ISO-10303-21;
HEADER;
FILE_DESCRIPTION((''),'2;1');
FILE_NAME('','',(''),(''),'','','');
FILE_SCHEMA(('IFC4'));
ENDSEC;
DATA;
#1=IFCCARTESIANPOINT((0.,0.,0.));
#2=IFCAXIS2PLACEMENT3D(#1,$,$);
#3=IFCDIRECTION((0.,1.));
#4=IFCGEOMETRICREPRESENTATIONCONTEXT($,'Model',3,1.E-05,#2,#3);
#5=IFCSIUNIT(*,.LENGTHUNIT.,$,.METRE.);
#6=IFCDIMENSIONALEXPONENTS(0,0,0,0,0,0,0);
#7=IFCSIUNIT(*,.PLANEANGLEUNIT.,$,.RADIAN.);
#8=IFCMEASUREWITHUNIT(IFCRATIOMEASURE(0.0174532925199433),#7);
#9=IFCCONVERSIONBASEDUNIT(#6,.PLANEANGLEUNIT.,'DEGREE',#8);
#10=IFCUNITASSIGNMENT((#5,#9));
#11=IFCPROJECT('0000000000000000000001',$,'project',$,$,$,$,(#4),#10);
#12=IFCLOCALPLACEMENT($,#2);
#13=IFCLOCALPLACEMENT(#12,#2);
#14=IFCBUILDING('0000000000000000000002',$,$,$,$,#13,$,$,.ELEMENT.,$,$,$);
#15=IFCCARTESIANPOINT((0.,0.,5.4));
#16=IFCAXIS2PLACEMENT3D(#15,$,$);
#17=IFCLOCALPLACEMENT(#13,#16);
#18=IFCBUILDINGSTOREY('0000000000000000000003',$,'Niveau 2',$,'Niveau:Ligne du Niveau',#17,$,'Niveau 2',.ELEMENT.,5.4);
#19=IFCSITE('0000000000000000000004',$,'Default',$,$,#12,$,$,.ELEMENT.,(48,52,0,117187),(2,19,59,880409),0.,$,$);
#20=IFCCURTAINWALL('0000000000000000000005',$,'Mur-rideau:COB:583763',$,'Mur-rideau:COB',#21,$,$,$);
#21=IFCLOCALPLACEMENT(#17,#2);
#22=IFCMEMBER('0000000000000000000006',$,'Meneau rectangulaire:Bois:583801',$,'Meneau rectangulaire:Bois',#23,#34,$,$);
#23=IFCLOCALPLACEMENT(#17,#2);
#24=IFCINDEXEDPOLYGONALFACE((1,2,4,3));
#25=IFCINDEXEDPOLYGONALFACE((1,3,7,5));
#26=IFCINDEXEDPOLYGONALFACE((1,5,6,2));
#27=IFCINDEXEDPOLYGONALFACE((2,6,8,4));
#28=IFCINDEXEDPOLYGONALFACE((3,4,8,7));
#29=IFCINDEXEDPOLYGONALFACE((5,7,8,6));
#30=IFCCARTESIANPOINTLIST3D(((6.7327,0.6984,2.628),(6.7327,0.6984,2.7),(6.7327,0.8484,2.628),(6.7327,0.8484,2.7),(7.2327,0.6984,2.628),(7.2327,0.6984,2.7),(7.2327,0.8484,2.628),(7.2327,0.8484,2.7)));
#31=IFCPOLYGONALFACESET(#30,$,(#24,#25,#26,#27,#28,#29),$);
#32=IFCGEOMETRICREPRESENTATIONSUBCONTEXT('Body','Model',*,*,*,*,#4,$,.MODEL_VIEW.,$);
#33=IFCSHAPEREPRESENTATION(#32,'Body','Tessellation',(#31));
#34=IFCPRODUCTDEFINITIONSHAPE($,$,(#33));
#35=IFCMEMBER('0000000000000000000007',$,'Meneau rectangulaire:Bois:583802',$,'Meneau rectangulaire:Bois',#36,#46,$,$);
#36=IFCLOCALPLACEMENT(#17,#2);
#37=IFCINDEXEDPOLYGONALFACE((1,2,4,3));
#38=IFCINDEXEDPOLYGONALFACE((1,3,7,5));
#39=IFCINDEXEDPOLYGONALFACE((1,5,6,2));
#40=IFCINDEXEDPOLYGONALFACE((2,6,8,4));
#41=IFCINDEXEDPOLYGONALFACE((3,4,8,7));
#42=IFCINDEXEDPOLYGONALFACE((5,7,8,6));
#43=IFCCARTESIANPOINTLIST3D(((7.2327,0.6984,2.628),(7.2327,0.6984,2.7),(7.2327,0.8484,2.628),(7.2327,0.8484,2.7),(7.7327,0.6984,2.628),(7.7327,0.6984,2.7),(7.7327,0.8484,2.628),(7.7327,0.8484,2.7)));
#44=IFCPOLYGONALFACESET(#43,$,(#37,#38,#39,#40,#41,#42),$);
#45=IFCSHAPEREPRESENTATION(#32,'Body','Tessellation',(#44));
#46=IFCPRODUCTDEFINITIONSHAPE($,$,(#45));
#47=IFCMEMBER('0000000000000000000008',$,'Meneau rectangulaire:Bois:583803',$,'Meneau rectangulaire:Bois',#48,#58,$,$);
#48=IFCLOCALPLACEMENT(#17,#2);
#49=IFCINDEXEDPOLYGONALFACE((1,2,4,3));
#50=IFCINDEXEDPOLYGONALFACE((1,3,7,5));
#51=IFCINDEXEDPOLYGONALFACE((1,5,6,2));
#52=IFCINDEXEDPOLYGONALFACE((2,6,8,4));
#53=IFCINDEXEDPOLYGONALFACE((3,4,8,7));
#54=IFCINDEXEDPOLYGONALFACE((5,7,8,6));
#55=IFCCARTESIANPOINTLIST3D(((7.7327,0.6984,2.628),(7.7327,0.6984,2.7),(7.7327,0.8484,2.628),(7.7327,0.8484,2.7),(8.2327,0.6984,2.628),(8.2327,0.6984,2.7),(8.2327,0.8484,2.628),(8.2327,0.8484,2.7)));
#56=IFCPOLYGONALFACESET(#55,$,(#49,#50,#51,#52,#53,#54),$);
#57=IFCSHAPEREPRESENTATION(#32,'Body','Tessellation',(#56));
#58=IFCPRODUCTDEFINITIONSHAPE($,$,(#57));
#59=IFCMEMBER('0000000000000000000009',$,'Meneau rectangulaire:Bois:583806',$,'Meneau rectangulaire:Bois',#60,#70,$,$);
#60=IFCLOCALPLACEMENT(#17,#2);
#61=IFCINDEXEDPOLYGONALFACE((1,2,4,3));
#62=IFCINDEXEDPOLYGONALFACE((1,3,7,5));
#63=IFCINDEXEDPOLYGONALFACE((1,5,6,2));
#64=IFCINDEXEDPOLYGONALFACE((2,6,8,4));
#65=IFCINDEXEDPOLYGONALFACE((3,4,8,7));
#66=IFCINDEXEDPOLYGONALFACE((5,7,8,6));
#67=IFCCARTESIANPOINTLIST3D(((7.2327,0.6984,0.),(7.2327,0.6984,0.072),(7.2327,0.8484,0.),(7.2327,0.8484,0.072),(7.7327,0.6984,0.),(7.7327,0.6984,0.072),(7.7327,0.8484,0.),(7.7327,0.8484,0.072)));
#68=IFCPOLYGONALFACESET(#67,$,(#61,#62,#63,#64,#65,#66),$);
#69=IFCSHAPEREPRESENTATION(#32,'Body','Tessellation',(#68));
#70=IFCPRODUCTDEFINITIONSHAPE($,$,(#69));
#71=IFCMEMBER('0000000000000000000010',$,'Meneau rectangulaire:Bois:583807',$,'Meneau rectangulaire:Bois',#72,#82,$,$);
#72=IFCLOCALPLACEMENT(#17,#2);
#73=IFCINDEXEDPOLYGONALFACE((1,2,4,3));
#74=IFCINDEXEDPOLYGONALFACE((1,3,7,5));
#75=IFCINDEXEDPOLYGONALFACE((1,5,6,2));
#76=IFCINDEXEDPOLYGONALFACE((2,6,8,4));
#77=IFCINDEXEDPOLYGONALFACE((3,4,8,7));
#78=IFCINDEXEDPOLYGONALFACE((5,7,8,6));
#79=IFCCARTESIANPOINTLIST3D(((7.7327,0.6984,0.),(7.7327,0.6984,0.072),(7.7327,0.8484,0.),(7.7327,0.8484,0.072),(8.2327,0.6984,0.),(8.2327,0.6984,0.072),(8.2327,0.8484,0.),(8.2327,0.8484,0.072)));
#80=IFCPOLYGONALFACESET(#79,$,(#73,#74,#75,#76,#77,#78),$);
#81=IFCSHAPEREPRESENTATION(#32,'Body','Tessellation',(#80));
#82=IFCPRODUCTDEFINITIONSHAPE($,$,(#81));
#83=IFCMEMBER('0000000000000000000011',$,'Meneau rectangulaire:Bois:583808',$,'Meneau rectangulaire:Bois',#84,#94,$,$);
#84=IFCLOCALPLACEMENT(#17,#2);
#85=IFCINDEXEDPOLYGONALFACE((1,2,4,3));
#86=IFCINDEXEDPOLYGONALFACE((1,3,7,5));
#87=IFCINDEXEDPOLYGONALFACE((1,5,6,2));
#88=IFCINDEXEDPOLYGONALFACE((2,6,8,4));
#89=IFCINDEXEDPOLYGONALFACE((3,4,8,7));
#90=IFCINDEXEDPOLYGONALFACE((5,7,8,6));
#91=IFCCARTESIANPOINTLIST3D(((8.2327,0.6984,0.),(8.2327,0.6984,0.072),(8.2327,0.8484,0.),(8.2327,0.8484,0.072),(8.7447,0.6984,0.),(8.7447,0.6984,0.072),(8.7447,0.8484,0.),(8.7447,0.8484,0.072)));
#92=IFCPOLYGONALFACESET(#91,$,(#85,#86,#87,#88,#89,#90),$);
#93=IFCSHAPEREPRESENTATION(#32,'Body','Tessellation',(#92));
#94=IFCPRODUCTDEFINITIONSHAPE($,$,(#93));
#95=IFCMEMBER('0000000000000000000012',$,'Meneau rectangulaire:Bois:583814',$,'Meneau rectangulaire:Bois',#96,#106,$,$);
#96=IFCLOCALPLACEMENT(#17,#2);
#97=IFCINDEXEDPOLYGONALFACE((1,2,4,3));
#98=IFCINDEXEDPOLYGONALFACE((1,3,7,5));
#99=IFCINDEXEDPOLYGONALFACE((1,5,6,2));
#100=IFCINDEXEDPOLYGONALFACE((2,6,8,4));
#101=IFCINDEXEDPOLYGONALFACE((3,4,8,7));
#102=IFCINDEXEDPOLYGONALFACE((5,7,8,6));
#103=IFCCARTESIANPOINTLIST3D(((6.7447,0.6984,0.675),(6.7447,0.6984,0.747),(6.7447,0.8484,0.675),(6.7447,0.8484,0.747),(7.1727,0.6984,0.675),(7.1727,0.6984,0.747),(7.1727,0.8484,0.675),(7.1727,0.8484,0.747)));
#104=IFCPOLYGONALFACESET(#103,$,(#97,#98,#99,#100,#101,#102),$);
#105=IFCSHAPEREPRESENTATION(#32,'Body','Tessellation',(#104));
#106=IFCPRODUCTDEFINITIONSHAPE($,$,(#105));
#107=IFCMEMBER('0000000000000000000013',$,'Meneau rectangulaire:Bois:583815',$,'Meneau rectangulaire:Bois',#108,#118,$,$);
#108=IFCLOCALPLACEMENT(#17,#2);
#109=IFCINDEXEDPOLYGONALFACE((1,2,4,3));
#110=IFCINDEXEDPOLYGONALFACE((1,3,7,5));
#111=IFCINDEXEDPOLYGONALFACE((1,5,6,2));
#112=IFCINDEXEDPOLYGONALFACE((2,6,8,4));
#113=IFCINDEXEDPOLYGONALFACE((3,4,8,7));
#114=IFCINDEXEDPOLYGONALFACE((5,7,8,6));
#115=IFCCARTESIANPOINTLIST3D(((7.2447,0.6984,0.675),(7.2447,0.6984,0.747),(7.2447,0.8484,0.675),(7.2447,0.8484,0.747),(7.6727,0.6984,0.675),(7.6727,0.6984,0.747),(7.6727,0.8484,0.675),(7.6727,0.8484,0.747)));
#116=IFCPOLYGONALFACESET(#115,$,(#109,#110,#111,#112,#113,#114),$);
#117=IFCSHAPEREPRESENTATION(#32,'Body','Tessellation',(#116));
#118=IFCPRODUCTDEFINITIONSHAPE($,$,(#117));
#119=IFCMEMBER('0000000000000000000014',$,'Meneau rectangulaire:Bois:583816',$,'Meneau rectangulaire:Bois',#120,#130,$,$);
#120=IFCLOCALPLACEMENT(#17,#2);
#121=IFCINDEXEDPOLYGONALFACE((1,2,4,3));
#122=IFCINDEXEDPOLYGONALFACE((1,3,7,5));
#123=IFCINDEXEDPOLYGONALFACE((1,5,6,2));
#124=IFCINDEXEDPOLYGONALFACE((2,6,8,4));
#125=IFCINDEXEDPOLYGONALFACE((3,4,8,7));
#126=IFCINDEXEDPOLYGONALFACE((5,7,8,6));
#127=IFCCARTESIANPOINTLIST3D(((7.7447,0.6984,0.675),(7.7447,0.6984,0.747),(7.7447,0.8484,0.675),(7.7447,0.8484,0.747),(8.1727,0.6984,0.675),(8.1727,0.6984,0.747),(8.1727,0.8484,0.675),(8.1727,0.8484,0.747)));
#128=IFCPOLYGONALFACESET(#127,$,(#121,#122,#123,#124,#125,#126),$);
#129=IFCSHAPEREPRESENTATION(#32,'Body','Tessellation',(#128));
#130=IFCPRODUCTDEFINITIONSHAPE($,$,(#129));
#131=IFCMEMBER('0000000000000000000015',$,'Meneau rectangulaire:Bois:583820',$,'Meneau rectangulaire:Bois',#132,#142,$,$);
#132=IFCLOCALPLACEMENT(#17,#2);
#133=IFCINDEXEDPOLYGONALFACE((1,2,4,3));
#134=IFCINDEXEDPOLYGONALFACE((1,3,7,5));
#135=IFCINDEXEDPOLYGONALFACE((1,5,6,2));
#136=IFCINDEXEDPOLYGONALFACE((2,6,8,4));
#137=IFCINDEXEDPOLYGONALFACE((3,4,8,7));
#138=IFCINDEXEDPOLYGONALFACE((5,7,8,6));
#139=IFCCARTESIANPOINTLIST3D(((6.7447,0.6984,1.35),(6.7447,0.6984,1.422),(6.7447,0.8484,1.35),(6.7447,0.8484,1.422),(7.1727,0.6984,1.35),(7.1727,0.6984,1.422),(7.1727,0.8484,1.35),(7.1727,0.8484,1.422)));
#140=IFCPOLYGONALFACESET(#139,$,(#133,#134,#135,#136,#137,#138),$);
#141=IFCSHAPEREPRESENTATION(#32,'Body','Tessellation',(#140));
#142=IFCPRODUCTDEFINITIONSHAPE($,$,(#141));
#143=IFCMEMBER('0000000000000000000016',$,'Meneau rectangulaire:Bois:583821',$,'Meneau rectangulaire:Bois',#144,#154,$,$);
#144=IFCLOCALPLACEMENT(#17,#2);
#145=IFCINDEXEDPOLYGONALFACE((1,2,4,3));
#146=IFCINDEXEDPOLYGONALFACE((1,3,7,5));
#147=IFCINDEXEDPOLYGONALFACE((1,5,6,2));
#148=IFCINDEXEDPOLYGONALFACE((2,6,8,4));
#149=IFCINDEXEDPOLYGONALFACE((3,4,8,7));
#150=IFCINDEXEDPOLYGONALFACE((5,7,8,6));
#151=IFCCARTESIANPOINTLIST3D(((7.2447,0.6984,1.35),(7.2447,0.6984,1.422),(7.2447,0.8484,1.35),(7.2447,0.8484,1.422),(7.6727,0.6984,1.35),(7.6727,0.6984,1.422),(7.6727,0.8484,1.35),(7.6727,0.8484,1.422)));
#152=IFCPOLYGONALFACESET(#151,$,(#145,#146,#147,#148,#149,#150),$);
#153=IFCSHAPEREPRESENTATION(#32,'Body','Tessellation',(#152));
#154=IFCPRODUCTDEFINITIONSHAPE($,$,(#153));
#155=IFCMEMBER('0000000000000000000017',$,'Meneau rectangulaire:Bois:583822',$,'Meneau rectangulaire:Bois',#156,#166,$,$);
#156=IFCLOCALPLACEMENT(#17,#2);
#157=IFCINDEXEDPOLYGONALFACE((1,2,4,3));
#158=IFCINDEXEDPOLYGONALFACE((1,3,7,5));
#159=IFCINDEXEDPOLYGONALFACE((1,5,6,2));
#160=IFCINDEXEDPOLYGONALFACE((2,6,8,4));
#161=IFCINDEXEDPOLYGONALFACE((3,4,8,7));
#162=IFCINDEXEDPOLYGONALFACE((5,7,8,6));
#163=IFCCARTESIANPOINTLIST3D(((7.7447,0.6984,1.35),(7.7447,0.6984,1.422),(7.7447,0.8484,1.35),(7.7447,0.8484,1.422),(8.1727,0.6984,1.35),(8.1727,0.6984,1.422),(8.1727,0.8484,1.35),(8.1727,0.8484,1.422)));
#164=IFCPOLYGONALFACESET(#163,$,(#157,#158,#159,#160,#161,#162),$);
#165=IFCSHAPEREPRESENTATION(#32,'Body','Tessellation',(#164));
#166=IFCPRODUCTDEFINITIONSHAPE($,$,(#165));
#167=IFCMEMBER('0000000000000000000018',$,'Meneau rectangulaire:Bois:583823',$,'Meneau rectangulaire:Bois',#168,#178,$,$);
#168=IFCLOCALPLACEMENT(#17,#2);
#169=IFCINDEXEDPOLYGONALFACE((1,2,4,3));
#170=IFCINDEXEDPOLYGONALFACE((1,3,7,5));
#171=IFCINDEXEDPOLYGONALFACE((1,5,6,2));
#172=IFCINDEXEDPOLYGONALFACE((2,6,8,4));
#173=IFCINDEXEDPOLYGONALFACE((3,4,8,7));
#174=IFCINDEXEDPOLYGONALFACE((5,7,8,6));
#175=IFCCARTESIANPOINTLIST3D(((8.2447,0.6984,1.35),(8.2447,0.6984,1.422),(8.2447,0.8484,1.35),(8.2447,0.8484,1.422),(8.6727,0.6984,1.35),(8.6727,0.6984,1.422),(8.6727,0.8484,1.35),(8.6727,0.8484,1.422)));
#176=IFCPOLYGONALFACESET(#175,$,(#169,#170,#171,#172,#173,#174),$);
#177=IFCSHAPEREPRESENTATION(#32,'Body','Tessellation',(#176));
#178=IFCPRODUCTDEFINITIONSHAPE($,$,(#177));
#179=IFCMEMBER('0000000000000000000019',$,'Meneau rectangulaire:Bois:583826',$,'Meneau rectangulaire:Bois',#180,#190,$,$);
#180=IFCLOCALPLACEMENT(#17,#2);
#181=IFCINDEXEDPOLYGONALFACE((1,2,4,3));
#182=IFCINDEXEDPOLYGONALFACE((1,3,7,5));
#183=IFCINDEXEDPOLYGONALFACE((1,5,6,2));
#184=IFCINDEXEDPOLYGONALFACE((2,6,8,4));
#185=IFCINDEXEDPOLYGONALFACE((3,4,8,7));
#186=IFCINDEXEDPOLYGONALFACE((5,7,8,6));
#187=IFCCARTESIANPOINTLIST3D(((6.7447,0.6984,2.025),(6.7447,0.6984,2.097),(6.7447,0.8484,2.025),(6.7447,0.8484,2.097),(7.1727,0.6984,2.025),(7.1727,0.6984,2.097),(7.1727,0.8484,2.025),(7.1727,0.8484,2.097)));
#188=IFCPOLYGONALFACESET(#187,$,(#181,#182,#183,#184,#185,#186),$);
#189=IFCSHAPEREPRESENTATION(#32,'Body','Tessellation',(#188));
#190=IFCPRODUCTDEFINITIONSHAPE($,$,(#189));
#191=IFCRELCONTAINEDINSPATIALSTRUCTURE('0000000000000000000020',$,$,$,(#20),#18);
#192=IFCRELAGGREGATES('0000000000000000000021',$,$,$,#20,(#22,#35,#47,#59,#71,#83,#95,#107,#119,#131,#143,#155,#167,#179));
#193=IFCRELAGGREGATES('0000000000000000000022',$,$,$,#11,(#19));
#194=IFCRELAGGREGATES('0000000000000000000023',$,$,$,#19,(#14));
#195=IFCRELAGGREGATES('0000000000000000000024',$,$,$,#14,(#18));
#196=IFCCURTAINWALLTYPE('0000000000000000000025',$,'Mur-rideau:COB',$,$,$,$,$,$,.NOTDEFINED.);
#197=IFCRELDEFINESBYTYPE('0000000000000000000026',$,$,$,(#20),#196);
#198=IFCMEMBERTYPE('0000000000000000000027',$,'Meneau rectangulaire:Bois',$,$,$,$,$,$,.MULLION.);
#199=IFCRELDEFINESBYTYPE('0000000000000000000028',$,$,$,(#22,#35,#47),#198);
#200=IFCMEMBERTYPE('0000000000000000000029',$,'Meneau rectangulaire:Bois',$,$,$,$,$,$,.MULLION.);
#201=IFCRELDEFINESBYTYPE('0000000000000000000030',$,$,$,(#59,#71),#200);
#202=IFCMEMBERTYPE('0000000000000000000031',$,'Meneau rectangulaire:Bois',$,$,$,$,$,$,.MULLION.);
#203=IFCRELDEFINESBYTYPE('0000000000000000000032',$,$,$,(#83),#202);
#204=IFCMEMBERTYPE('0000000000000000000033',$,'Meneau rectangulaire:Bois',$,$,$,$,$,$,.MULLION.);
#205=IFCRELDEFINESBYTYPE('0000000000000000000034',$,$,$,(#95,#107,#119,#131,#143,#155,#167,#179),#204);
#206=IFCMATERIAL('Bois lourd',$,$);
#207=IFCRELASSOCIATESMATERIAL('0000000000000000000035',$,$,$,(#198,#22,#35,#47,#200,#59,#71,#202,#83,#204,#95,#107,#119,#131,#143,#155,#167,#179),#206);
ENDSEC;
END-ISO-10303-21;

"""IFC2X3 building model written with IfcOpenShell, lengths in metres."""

from ifc_helpers import new_model, entity, si_unit, converted_unit, direction, frame, origin, origin_2d_with_axis, place, context, subcontext, project, spatial, rectangle, extrude, source, transform, mapped, material, type_object, type_shapes, element, aggregate, save


model = new_model("IFC2X3")

# Units and contexts
model_context = context("Model", 3, precision=1e-05, world=origin(), true_north=direction((0.0, 1.0)))
body_context = subcontext(model_context, "Body", "Model", "MODEL_VIEW")
ifc_project = project(units=[si_unit("LENGTHUNIT", "METRE"), converted_unit("PLANEANGLEUNIT", "DEGREE", entity("IfcRatioMeasure", 0.0174532925199433), si_unit("PLANEANGLEUNIT", "RADIAN"), dimensions=[0, 0, 0, 0, 0, 0, 0])], contexts=[model_context])

# Site, building, storey
site_placement = place(None, origin())
site = spatial("IfcSite", under=ifc_project, at=site_placement, Name="Default", CompositionType="ELEMENT", RefLatitude=(48, 52, 0, 117187), RefLongitude=(2, 19, 59, 880409), RefElevation=0.0)
building_placement = place(site_placement, origin())
building = spatial("IfcBuilding", under=site, at=building_placement, CompositionType="ELEMENT")
storey_placement = place(building_placement, frame((0.0, 0.0, 5.4)))
storey = spatial("IfcBuildingStorey", under=building, at=storey_placement, Name="Niveau 2", ObjectType="Niveau:Ligne du Niveau", LongName="Niveau 2", CompositionType="ELEMENT", Elevation=5.4)

# Curtain wall, members
curtain_wall_type_1 = type_object("IfcCurtainWallType", Name="Mur-rideau:COB", PredefinedType="NOTDEFINED")
curtain_wall_1_placement = place(storey_placement, frame((0.0, 0.0, -5.4)))
curtain_wall_1 = element("IfcCurtainWall", 1, at=curtain_wall_1_placement, inside=storey, type_object=curtain_wall_type_1, Name="Mur-rideau:COB:583763", ObjectType="Mur-rideau:COB")
ifc_material_1 = material(Name="Bois lourd")
member_type_1 = type_object("IfcMemberType", Name="Meneau rectangulaire:Bois", PredefinedType="MULLION", material=ifc_material_1)
shared_shape_1 = source(origin(), body_context, "Body", "SweptSolid", [
    extrude(rectangle(XDim=0.15, YDim=0.072, at=origin_2d_with_axis()), frame((-0.036, 0.0, -0.5), z_axis=(0.0, 0.0, 1.0), x_axis=(0.0, -1.0, 0.0)), (0.0, 0.0, 1.0), 0.5),
])
type_shapes(member_type_1, [shared_shape_1])
member_1_placement = place(storey_placement, frame((7.2327, 0.7734, 2.7), z_axis=(1.0, 0.0, 0.0), x_axis=(0.0, 0.0, 1.0)))
member_1 = element("IfcMember", 2, at=member_1_placement, type_object=member_type_1, material=ifc_material_1, Name="Meneau rectangulaire:Bois:583801", ObjectType="Meneau rectangulaire:Bois", context=body_context, shape_type="MappedRepresentation", body=[
    mapped(shared_shape_1, transform((0.0, 0.0, 0.0), scale=1.0)),
])
member_2_placement = place(storey_placement, frame((7.7327, 0.7734, 2.7), z_axis=(1.0, 0.0, 0.0), x_axis=(0.0, 0.0, 1.0)))
member_2 = element("IfcMember", 3, at=member_2_placement, type_object=member_type_1, material=ifc_material_1, Name="Meneau rectangulaire:Bois:583802", ObjectType="Meneau rectangulaire:Bois", context=body_context, shape_type="MappedRepresentation", body=[
    mapped(shared_shape_1, transform((0.0, 0.0, 0.0), scale=1.0)),
])
member_3_placement = place(storey_placement, frame((8.2327, 0.7734, 2.7), z_axis=(1.0, 0.0, 0.0), x_axis=(0.0, 0.0, 1.0)))
member_3 = element("IfcMember", 4, at=member_3_placement, type_object=member_type_1, material=ifc_material_1, Name="Meneau rectangulaire:Bois:583803", ObjectType="Meneau rectangulaire:Bois", context=body_context, shape_type="MappedRepresentation", body=[
    mapped(shared_shape_1, transform((0.0, 0.0, 0.0), scale=1.0)),
])
member_type_2 = type_object("IfcMemberType", Name="Meneau rectangulaire:Bois", PredefinedType="MULLION", material=ifc_material_1)
shared_shape_2 = source(origin(), body_context, "Body", "SweptSolid", [
    extrude(rectangle(XDim=0.15, YDim=0.072, at=origin_2d_with_axis()), frame((-0.036, 0.0, -0.5), z_axis=(0.0, 0.0, 1.0), x_axis=(0.0, -1.0, 0.0)), (0.0, 0.0, 1.0), 0.5),
])
type_shapes(member_type_2, [shared_shape_2])
member_4_placement = place(storey_placement, frame((7.2327, 0.7734, 0.0), z_axis=(-1.0, 0.0, 0.0), x_axis=(0.0, 0.0, -1.0)))
member_4 = element("IfcMember", 5, at=member_4_placement, type_object=member_type_2, material=ifc_material_1, Name="Meneau rectangulaire:Bois:583806", ObjectType="Meneau rectangulaire:Bois", context=body_context, shape_type="MappedRepresentation", body=[
    mapped(shared_shape_2, transform((0.0, 0.0, 0.0), scale=1.0)),
])
member_5_placement = place(storey_placement, frame((7.7327, 0.7734, 0.0), z_axis=(-1.0, 0.0, 0.0), x_axis=(0.0, 0.0, -1.0)))
member_5 = element("IfcMember", 6, at=member_5_placement, type_object=member_type_2, material=ifc_material_1, Name="Meneau rectangulaire:Bois:583807", ObjectType="Meneau rectangulaire:Bois", context=body_context, shape_type="MappedRepresentation", body=[
    mapped(shared_shape_2, transform((0.0, 0.0, 0.0), scale=1.0)),
])
member_type_3 = type_object("IfcMemberType", Name="Meneau rectangulaire:Bois", PredefinedType="MULLION", material=ifc_material_1)
shared_shape_3 = source(origin(), body_context, "Body", "SweptSolid", [
    extrude(rectangle(XDim=0.15, YDim=0.072, at=origin_2d_with_axis()), frame((-0.036, 0.0, -0.512), z_axis=(0.0, 0.0, 1.0), x_axis=(0.0, -1.0, 0.0)), (0.0, 0.0, 1.0), 0.512),
])
type_shapes(member_type_3, [shared_shape_3])
member_6_placement = place(storey_placement, frame((8.2327, 0.7734, 0.0), z_axis=(-1.0, 0.0, 0.0), x_axis=(0.0, 0.0, -1.0)))
member_6 = element("IfcMember", 7, at=member_6_placement, type_object=member_type_3, material=ifc_material_1, Name="Meneau rectangulaire:Bois:583808", ObjectType="Meneau rectangulaire:Bois", context=body_context, shape_type="MappedRepresentation", body=[
    mapped(shared_shape_3, transform((0.0, 0.0, 0.0), scale=1.0)),
])
member_type_4 = type_object("IfcMemberType", Name="Meneau rectangulaire:Bois", PredefinedType="MULLION", material=ifc_material_1)
shared_shape_4 = source(origin(), body_context, "Body", "SweptSolid", [
    extrude(rectangle(XDim=0.15, YDim=0.072, at=origin_2d_with_axis()), frame((-0.024, 0.0, -0.428), z_axis=(0.0, 0.0, 1.0), x_axis=(0.0, -1.0, 0.0)), (0.0, 0.0, 1.0), 0.428),
])
type_shapes(member_type_4, [shared_shape_4])
member_7_placement = place(storey_placement, frame((7.1727, 0.7734, 0.735), z_axis=(1.0, 0.0, 0.0), x_axis=(0.0, 0.0, 1.0)))
member_7 = element("IfcMember", 8, at=member_7_placement, type_object=member_type_4, material=ifc_material_1, Name="Meneau rectangulaire:Bois:583814", ObjectType="Meneau rectangulaire:Bois", context=body_context, shape_type="MappedRepresentation", body=[
    mapped(shared_shape_4, transform((0.0, 0.0, 0.0), scale=1.0)),
])
member_8_placement = place(storey_placement, frame((7.6727, 0.7734, 0.735), z_axis=(1.0, 0.0, 0.0), x_axis=(0.0, 0.0, 1.0)))
member_8 = element("IfcMember", 9, at=member_8_placement, type_object=member_type_4, material=ifc_material_1, Name="Meneau rectangulaire:Bois:583815", ObjectType="Meneau rectangulaire:Bois", context=body_context, shape_type="MappedRepresentation", body=[
    mapped(shared_shape_4, transform((0.0, 0.0, 0.0), scale=1.0)),
])
member_9_placement = place(storey_placement, frame((8.1727, 0.7734, 0.735), z_axis=(1.0, 0.0, 0.0), x_axis=(0.0, 0.0, 1.0)))
member_9 = element("IfcMember", 10, at=member_9_placement, type_object=member_type_4, material=ifc_material_1, Name="Meneau rectangulaire:Bois:583816", ObjectType="Meneau rectangulaire:Bois", context=body_context, shape_type="MappedRepresentation", body=[
    mapped(shared_shape_4, transform((0.0, 0.0, 0.0), scale=1.0)),
])
member_10_placement = place(storey_placement, frame((7.1727, 0.7734, 1.41), z_axis=(1.0, 0.0, 0.0), x_axis=(0.0, 0.0, 1.0)))
member_10 = element("IfcMember", 11, at=member_10_placement, type_object=member_type_4, material=ifc_material_1, Name="Meneau rectangulaire:Bois:583820", ObjectType="Meneau rectangulaire:Bois", context=body_context, shape_type="MappedRepresentation", body=[
    mapped(shared_shape_4, transform((0.0, 0.0, 0.0), scale=1.0)),
])
member_11_placement = place(storey_placement, frame((7.6727, 0.7734, 1.41), z_axis=(1.0, 0.0, 0.0), x_axis=(0.0, 0.0, 1.0)))
member_11 = element("IfcMember", 12, at=member_11_placement, type_object=member_type_4, material=ifc_material_1, Name="Meneau rectangulaire:Bois:583821", ObjectType="Meneau rectangulaire:Bois", context=body_context, shape_type="MappedRepresentation", body=[
    mapped(shared_shape_4, transform((0.0, 0.0, 0.0), scale=1.0)),
])
member_12_placement = place(storey_placement, frame((8.1727, 0.7734, 1.41), z_axis=(1.0, 0.0, 0.0), x_axis=(0.0, 0.0, 1.0)))
member_12 = element("IfcMember", 13, at=member_12_placement, type_object=member_type_4, material=ifc_material_1, Name="Meneau rectangulaire:Bois:583822", ObjectType="Meneau rectangulaire:Bois", context=body_context, shape_type="MappedRepresentation", body=[
    mapped(shared_shape_4, transform((0.0, 0.0, 0.0), scale=1.0)),
])
member_13_placement = place(storey_placement, frame((8.6727, 0.7734, 1.41), z_axis=(1.0, 0.0, 0.0), x_axis=(0.0, 0.0, 1.0)))
member_13 = element("IfcMember", 14, at=member_13_placement, type_object=member_type_4, material=ifc_material_1, Name="Meneau rectangulaire:Bois:583823", ObjectType="Meneau rectangulaire:Bois", context=body_context, shape_type="MappedRepresentation", body=[
    mapped(shared_shape_4, transform((0.0, 0.0, 0.0), scale=1.0)),
])
member_14_placement = place(storey_placement, frame((7.1727, 0.7734, 2.085), z_axis=(1.0, 0.0, 0.0), x_axis=(0.0, 0.0, 1.0)))
member_14 = element("IfcMember", 15, at=member_14_placement, type_object=member_type_4, material=ifc_material_1, Name="Meneau rectangulaire:Bois:583826", ObjectType="Meneau rectangulaire:Bois", context=body_context, shape_type="MappedRepresentation", body=[
    mapped(shared_shape_4, transform((0.0, 0.0, 0.0), scale=1.0)),
])
aggregate(curtain_wall_1, [member_1, member_2, member_3, member_4, member_5, member_6, member_7, member_8, member_9, member_10, member_11, member_12, member_13, member_14])

save(model, "model.ifc")
